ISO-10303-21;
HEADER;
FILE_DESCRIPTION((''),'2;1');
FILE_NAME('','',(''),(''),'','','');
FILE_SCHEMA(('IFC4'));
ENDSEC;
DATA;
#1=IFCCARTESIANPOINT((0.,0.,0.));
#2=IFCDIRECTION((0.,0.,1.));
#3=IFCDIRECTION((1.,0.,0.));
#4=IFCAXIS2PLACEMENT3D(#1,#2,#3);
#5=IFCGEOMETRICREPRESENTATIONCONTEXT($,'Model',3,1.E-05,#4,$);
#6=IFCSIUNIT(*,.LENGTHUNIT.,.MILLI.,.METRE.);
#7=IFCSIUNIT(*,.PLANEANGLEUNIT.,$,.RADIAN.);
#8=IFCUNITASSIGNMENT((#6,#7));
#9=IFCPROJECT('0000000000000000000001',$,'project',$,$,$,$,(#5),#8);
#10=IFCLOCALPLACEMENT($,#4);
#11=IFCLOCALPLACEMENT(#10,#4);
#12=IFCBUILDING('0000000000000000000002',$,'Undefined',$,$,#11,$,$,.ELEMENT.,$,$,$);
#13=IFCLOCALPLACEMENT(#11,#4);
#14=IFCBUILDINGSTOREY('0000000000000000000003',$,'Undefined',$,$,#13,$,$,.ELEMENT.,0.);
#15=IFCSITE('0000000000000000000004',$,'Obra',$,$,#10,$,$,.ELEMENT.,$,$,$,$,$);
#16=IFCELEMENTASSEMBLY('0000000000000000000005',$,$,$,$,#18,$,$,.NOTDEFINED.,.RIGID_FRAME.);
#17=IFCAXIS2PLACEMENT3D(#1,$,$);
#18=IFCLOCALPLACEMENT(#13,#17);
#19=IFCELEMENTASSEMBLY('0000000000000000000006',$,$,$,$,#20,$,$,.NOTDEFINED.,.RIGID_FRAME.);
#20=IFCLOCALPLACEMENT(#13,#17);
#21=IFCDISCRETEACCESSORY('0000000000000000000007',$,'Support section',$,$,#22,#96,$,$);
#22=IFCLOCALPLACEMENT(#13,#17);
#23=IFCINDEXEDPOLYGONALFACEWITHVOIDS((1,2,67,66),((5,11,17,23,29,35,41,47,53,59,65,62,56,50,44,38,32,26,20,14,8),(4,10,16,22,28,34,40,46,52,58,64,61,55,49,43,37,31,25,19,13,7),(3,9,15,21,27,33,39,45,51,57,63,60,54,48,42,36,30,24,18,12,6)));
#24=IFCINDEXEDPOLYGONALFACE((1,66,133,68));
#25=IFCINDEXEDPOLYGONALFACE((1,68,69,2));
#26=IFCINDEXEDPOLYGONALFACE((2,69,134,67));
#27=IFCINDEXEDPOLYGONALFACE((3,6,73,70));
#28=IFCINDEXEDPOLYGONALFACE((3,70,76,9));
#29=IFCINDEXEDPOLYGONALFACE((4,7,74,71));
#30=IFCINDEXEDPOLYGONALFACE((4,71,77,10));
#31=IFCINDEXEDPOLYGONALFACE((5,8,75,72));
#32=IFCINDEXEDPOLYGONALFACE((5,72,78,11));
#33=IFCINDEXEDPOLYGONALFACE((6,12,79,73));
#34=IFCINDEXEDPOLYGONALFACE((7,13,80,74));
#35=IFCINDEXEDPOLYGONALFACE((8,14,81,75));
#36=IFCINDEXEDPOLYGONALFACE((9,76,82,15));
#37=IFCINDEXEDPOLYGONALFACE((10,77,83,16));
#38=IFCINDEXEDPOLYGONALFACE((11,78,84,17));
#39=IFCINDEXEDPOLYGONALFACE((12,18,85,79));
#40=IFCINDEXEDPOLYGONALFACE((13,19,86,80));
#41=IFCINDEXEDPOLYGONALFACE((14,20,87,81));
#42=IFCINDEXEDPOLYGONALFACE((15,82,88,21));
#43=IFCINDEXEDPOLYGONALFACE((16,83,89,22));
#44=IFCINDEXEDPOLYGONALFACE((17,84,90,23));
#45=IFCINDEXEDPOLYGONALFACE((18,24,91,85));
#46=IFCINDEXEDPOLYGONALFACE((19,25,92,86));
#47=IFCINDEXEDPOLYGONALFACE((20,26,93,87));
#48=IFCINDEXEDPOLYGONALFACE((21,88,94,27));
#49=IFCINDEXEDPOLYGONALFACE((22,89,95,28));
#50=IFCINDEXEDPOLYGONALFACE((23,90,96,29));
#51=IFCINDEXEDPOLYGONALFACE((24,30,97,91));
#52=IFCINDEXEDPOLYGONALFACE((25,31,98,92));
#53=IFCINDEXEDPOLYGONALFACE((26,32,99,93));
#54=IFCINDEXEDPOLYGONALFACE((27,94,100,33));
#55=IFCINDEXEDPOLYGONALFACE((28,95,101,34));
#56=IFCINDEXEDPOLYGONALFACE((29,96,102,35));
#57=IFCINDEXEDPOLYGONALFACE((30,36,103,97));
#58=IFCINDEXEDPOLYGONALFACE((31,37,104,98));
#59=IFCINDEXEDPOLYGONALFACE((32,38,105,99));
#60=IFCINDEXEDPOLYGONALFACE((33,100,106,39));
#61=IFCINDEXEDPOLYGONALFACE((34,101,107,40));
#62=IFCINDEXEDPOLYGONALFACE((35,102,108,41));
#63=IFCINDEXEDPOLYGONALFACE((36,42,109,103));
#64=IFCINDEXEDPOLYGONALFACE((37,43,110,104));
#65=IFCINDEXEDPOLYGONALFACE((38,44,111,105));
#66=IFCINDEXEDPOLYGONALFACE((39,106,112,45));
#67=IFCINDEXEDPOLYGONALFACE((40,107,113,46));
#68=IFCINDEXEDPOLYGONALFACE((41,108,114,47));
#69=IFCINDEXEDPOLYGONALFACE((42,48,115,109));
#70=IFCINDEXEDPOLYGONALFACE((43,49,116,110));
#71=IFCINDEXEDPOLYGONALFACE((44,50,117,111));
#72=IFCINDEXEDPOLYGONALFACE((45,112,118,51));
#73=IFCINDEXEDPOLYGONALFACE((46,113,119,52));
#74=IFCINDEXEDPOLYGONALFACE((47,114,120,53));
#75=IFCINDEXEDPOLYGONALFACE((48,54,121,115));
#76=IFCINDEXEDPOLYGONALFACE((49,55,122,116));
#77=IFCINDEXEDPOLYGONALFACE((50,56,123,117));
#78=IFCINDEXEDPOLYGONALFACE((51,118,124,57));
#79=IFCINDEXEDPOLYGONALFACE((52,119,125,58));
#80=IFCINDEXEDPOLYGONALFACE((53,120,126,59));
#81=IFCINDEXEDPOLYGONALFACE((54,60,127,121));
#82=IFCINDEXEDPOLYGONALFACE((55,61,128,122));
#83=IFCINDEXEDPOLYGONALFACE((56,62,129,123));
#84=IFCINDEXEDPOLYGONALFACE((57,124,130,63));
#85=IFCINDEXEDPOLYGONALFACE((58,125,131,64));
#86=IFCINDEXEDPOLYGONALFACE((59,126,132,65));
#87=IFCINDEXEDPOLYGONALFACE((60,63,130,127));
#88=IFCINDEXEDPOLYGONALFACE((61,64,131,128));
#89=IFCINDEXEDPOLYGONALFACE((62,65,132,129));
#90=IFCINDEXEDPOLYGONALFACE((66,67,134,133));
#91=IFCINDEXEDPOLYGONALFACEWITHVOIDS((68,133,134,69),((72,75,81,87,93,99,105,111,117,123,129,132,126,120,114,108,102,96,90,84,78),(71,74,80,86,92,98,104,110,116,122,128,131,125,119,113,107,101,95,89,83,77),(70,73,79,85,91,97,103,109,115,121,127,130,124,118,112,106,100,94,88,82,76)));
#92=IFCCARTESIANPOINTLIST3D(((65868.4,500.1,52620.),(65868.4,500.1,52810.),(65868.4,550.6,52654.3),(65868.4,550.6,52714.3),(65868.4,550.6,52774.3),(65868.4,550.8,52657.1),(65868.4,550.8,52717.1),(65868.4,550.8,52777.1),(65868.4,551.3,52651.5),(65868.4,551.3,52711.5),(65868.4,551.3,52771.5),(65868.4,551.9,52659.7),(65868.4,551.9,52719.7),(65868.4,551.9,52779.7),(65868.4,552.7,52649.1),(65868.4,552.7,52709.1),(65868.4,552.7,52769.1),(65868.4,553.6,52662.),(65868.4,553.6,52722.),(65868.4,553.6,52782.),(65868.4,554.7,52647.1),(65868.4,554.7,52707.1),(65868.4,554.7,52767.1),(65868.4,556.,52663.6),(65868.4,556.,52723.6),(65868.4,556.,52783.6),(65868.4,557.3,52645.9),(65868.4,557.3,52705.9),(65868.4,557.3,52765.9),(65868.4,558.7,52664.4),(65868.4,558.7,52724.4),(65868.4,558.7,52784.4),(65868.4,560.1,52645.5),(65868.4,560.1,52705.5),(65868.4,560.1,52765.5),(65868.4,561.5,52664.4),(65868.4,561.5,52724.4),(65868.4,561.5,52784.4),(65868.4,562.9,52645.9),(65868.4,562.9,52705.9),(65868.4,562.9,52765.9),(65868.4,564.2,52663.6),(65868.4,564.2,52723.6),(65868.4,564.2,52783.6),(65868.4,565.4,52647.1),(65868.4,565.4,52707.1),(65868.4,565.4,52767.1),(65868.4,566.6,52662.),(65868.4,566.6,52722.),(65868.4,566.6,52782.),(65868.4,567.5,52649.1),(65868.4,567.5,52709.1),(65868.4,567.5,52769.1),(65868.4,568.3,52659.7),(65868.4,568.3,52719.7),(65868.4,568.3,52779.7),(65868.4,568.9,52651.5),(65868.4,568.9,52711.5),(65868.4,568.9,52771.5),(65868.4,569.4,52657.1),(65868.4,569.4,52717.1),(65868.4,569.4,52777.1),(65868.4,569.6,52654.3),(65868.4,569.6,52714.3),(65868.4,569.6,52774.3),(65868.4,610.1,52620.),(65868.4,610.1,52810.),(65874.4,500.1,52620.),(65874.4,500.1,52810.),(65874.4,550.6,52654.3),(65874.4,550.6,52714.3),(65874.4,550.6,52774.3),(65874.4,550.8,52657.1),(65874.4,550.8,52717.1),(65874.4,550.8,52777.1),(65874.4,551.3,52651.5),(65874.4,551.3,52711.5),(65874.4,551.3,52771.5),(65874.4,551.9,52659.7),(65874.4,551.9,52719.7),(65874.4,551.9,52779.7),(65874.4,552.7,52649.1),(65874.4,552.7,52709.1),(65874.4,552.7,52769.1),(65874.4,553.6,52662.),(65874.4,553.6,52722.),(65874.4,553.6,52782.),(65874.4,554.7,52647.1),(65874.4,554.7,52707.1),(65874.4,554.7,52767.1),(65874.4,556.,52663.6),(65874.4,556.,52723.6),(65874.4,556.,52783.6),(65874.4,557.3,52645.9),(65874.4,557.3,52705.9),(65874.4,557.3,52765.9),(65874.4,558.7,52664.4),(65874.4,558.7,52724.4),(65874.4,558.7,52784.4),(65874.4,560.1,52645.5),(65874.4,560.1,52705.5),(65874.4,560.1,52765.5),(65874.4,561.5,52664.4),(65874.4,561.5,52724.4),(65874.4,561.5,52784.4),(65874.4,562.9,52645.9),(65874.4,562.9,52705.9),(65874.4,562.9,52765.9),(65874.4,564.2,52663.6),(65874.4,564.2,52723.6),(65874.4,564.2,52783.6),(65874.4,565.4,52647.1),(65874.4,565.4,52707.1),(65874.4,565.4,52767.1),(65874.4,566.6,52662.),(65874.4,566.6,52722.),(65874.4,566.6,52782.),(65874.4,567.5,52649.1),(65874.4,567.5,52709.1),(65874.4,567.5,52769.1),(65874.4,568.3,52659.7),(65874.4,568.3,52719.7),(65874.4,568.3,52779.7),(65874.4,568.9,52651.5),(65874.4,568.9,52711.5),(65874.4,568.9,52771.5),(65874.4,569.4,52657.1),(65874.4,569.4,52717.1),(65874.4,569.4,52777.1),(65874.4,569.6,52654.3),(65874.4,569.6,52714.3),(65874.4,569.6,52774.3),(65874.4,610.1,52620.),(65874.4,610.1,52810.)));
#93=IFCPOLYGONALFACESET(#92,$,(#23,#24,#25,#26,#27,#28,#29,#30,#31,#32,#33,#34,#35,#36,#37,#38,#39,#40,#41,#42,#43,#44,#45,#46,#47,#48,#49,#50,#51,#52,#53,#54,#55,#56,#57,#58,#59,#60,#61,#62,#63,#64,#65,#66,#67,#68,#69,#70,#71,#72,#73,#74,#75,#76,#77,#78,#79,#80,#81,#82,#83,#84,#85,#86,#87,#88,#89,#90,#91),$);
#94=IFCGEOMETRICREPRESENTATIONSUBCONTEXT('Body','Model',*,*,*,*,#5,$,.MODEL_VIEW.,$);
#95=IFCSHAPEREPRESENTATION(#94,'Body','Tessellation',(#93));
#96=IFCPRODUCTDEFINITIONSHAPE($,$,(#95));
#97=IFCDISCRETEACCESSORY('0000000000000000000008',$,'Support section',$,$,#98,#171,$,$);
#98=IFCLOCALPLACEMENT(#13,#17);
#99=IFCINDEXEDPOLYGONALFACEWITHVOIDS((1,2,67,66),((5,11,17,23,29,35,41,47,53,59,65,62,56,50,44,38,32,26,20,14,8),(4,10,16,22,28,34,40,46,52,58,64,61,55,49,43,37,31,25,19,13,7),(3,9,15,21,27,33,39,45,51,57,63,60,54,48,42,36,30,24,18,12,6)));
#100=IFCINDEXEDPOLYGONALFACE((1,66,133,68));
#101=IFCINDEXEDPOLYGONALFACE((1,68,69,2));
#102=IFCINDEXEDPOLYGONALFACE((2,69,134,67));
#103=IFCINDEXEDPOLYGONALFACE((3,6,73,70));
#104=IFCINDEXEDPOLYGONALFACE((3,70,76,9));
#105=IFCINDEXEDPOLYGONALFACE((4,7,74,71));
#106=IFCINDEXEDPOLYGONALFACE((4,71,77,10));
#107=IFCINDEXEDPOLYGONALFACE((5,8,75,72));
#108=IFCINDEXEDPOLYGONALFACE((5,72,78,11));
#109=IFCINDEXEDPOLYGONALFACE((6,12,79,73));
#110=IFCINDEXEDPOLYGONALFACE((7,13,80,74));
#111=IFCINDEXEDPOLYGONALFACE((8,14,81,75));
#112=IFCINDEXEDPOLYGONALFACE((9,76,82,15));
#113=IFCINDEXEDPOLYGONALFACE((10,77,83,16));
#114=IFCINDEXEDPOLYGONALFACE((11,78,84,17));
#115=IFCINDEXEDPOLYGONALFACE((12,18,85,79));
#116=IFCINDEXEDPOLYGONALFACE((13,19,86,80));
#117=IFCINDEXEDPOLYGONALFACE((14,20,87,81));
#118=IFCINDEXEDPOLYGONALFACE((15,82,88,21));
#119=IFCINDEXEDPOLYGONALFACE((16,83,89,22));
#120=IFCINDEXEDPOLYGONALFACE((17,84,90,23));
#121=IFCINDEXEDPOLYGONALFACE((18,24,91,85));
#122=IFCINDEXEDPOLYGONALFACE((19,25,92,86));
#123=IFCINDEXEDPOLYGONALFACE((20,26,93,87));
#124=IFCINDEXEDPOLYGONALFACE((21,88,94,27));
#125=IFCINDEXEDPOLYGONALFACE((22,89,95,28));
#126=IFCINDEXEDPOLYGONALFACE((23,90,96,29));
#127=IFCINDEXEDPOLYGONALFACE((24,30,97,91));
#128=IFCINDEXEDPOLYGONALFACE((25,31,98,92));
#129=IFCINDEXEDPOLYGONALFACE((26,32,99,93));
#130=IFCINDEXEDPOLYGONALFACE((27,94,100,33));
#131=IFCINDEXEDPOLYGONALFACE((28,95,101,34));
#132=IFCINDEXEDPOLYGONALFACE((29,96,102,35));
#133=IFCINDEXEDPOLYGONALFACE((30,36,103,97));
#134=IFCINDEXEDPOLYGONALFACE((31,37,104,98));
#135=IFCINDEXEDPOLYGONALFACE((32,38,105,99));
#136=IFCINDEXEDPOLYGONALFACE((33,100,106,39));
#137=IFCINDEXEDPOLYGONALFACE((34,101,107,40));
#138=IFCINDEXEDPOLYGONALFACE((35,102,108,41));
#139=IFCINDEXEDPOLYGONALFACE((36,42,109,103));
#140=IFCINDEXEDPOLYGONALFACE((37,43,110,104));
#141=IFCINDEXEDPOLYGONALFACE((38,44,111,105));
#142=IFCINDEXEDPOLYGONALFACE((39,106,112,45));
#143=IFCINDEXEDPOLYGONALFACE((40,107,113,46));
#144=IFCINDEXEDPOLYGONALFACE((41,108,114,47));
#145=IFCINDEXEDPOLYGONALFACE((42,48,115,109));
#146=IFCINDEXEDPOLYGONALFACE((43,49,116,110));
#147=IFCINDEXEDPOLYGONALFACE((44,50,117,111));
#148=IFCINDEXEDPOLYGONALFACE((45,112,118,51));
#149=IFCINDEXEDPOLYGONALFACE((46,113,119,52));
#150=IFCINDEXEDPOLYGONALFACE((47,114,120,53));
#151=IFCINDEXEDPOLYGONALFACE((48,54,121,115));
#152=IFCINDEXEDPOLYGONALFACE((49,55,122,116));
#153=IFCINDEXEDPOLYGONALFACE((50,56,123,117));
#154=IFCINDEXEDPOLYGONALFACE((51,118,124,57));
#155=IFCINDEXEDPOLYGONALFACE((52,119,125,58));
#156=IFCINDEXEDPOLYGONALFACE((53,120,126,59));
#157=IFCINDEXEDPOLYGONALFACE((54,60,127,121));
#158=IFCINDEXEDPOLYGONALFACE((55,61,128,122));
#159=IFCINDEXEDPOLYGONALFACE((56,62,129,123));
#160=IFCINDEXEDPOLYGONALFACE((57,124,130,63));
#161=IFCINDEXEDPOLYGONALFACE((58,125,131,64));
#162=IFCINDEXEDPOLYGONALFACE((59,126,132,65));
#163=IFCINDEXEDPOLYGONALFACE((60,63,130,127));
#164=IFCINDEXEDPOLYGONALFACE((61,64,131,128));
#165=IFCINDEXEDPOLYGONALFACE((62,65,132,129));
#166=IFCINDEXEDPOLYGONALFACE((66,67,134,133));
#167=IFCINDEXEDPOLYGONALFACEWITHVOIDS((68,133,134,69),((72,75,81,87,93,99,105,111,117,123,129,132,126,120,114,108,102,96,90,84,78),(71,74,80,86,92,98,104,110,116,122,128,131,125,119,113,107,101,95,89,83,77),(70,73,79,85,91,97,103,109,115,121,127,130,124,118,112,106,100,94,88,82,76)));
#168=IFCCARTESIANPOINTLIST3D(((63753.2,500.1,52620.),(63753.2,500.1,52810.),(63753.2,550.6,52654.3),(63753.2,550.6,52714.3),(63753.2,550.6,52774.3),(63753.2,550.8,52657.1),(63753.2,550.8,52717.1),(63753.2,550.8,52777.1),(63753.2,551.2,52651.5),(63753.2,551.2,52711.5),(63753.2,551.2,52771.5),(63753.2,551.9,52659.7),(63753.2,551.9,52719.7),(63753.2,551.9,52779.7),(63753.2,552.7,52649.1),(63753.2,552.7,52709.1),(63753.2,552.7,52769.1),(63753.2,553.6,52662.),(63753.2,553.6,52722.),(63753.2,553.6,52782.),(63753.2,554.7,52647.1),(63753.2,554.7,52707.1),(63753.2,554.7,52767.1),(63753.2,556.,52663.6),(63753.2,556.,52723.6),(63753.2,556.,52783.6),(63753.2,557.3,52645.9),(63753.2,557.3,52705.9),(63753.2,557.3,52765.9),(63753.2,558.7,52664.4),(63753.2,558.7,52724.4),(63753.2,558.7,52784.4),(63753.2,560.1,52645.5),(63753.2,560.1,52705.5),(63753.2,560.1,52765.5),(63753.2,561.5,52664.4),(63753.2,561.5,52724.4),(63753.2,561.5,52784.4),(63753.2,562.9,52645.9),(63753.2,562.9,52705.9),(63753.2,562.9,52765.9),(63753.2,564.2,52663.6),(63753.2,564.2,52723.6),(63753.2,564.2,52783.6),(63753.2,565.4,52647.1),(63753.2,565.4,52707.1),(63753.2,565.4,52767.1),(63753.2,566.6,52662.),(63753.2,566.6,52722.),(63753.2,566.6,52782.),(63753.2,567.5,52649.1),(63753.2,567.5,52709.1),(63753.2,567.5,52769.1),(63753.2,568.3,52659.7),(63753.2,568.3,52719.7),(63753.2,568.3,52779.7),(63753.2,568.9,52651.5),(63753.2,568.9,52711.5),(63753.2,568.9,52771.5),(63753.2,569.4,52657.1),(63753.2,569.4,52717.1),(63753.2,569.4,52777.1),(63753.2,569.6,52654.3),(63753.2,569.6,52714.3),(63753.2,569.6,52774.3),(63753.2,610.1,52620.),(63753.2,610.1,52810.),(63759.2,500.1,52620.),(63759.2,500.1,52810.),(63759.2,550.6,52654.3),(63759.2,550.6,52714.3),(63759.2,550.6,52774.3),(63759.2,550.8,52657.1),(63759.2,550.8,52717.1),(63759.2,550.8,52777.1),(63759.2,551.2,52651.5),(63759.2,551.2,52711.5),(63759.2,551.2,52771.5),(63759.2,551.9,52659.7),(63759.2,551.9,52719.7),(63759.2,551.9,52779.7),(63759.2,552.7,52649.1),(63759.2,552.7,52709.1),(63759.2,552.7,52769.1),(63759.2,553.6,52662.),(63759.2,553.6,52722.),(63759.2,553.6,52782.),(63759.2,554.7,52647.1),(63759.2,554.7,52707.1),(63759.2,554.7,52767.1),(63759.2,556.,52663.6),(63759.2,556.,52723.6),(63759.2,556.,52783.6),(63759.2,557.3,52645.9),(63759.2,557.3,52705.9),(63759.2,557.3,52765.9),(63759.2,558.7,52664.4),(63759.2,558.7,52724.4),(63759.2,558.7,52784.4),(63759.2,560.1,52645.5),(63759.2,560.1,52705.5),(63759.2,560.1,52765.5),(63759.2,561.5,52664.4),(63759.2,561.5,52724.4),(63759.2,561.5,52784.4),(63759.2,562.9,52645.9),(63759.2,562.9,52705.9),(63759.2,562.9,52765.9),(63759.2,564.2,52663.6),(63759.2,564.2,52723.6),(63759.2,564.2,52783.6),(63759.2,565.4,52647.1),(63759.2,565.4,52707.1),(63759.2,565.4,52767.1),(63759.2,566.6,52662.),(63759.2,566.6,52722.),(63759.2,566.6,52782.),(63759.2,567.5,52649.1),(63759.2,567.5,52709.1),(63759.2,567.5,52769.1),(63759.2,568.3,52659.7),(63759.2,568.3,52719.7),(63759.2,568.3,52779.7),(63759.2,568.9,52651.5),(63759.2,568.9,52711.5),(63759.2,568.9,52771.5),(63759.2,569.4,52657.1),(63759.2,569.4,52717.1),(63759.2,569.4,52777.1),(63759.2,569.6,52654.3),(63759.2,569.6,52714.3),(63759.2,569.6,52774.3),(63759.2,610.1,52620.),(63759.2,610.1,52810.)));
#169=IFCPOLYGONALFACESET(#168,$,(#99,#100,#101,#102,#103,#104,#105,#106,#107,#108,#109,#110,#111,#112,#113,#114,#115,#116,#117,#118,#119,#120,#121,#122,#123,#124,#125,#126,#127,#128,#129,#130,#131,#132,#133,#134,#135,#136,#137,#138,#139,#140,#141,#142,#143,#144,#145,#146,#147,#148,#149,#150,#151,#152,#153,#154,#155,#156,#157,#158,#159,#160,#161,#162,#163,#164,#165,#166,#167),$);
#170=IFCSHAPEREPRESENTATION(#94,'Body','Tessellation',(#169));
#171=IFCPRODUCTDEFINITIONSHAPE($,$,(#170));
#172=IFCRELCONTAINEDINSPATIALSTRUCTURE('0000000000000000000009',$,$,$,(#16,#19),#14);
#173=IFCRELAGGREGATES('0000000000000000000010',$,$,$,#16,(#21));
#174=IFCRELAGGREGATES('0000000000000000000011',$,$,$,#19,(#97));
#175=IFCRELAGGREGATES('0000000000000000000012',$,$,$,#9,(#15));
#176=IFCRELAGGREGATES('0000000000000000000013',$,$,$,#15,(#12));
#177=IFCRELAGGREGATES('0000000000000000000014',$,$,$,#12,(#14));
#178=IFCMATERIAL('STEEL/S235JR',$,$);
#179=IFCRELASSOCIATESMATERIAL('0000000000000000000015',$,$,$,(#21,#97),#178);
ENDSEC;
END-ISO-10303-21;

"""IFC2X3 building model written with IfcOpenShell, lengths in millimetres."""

from ifc_helpers import new_model, si_unit, frame, origin_with_axes, origin_2d_with_axis, place, context, subcontext, project, spatial, rectangle, circle, extrude, source, transform, mapped, material, element, aggregate, save


model = new_model("IFC2X3")

# Units and contexts
model_context = context("Model", 3, precision=1e-05, world=origin_with_axes())
body_context = subcontext(model_context, "Body", "Model", "MODEL_VIEW")
ifc_project = project(units=[si_unit("LENGTHUNIT", "METRE", prefix="MILLI"), si_unit("PLANEANGLEUNIT", "RADIAN")], contexts=[model_context])

# Site, building, storey
site_placement = place(None, origin_with_axes())
site = spatial("IfcSite", under=ifc_project, at=site_placement, Name="Obra", CompositionType="ELEMENT")
building_placement = place(site_placement, origin_with_axes())
building = spatial("IfcBuilding", under=site, at=building_placement, Name="Undefined", CompositionType="ELEMENT")
storey_placement = place(building_placement, origin_with_axes())
storey = spatial("IfcBuildingStorey", under=building, at=storey_placement, Name="Undefined", CompositionType="ELEMENT", Elevation=0.0)

# Element assemblies
assembly_1_placement = place(storey_placement, origin_with_axes())
assembly_1 = element("IfcElementAssembly", 1, at=assembly_1_placement, inside=storey, AssemblyPlace="NOTDEFINED", PredefinedType="RIGID_FRAME")
ifc_material_1 = material(Name="STEEL/S235JR")
assembly_2_placement = place(storey_placement, origin_with_axes())
assembly_2 = element("IfcElementAssembly", 2, at=assembly_2_placement, inside=storey, AssemblyPlace="NOTDEFINED", PredefinedType="RIGID_FRAME")

# Discrete accessories, openings
discrete_accessory_1_placement = place(assembly_1_placement, frame((65871.4, 555.1, 52620.0), z_axis=(0.0, 0.0, 1.0), x_axis=(0.000002, -1.0, 0.0)))
discrete_accessory_1 = element("IfcDiscreteAccessory", 3, at=discrete_accessory_1_placement, material=ifc_material_1, Name="Support section", context=body_context, shape_type="SweptSolid", body=[
    extrude(rectangle(XDim=6.0, YDim=110.0, at=origin_2d_with_axis()), frame((0.0, 0.0, 190.0), z_axis=(0.0, 0.0, -1.0), x_axis=(0.0, 1.0, 0.0)), (0.0, 0.0, 1.0), 190.0),
])
shared_shape_1 = source(origin_with_axes(), body_context, "Body", "SweptSolid", [
    extrude(circle(Radius=9.5, at=origin_2d_with_axis()), frame((0.0, -9.2, 0.0), z_axis=(0.0, 1.0, 0.0), x_axis=(1.0, 0.0, 0.0)), (0.0, 0.0, 1.0), 6.2),
])
opening_1_placement = place(assembly_1_placement, frame((65865.3, 510.1, 52835.0), z_axis=(-0.000002, 1.0, 0.0), x_axis=(0.0, 0.0, -1.0)))
element("IfcOpeningElement", 4, at=opening_1_placement, cuts=discrete_accessory_1, ObjectType="Opening", context=body_context, shape_type="MappedRepresentation", body=[
    mapped(shared_shape_1, transform((60.0, 0.0, 50.0))),
    mapped(shared_shape_1, transform((120.0, 0.0, 50.0))),
    mapped(shared_shape_1, transform((180.0, 0.0, 50.0))),
])
aggregate(assembly_1, [discrete_accessory_1])
discrete_accessory_2_placement = place(assembly_2_placement, frame((63756.2, 555.1, 52620.0), z_axis=(0.0, 0.0, 1.0), x_axis=(0.000002, -1.0, 0.0)))
discrete_accessory_2 = element("IfcDiscreteAccessory", 5, at=discrete_accessory_2_placement, material=ifc_material_1, Name="Support section", context=body_context, shape_type="SweptSolid", body=[
    extrude(rectangle(XDim=6.0, YDim=110.0, at=origin_2d_with_axis()), frame((0.0, 0.0, 190.0), z_axis=(0.0, 0.0, -1.0), x_axis=(0.0, 1.0, 0.0)), (0.0, 0.0, 1.0), 190.0),
])
opening_2_placement = place(assembly_2_placement, frame((63750.1, 510.1, 52835.0), z_axis=(-0.000002, 1.0, 0.0), x_axis=(0.0, 0.0, -1.0)))
element("IfcOpeningElement", 6, at=opening_2_placement, cuts=discrete_accessory_2, ObjectType="Opening", context=body_context, shape_type="MappedRepresentation", body=[
    mapped(shared_shape_1, transform((60.0, 0.0, 50.0))),
    mapped(shared_shape_1, transform((120.0, 0.0, 50.0))),
    mapped(shared_shape_1, transform((180.0, 0.0, 50.0))),
])
aggregate(assembly_2, [discrete_accessory_2])

save(model, "model.ifc")
